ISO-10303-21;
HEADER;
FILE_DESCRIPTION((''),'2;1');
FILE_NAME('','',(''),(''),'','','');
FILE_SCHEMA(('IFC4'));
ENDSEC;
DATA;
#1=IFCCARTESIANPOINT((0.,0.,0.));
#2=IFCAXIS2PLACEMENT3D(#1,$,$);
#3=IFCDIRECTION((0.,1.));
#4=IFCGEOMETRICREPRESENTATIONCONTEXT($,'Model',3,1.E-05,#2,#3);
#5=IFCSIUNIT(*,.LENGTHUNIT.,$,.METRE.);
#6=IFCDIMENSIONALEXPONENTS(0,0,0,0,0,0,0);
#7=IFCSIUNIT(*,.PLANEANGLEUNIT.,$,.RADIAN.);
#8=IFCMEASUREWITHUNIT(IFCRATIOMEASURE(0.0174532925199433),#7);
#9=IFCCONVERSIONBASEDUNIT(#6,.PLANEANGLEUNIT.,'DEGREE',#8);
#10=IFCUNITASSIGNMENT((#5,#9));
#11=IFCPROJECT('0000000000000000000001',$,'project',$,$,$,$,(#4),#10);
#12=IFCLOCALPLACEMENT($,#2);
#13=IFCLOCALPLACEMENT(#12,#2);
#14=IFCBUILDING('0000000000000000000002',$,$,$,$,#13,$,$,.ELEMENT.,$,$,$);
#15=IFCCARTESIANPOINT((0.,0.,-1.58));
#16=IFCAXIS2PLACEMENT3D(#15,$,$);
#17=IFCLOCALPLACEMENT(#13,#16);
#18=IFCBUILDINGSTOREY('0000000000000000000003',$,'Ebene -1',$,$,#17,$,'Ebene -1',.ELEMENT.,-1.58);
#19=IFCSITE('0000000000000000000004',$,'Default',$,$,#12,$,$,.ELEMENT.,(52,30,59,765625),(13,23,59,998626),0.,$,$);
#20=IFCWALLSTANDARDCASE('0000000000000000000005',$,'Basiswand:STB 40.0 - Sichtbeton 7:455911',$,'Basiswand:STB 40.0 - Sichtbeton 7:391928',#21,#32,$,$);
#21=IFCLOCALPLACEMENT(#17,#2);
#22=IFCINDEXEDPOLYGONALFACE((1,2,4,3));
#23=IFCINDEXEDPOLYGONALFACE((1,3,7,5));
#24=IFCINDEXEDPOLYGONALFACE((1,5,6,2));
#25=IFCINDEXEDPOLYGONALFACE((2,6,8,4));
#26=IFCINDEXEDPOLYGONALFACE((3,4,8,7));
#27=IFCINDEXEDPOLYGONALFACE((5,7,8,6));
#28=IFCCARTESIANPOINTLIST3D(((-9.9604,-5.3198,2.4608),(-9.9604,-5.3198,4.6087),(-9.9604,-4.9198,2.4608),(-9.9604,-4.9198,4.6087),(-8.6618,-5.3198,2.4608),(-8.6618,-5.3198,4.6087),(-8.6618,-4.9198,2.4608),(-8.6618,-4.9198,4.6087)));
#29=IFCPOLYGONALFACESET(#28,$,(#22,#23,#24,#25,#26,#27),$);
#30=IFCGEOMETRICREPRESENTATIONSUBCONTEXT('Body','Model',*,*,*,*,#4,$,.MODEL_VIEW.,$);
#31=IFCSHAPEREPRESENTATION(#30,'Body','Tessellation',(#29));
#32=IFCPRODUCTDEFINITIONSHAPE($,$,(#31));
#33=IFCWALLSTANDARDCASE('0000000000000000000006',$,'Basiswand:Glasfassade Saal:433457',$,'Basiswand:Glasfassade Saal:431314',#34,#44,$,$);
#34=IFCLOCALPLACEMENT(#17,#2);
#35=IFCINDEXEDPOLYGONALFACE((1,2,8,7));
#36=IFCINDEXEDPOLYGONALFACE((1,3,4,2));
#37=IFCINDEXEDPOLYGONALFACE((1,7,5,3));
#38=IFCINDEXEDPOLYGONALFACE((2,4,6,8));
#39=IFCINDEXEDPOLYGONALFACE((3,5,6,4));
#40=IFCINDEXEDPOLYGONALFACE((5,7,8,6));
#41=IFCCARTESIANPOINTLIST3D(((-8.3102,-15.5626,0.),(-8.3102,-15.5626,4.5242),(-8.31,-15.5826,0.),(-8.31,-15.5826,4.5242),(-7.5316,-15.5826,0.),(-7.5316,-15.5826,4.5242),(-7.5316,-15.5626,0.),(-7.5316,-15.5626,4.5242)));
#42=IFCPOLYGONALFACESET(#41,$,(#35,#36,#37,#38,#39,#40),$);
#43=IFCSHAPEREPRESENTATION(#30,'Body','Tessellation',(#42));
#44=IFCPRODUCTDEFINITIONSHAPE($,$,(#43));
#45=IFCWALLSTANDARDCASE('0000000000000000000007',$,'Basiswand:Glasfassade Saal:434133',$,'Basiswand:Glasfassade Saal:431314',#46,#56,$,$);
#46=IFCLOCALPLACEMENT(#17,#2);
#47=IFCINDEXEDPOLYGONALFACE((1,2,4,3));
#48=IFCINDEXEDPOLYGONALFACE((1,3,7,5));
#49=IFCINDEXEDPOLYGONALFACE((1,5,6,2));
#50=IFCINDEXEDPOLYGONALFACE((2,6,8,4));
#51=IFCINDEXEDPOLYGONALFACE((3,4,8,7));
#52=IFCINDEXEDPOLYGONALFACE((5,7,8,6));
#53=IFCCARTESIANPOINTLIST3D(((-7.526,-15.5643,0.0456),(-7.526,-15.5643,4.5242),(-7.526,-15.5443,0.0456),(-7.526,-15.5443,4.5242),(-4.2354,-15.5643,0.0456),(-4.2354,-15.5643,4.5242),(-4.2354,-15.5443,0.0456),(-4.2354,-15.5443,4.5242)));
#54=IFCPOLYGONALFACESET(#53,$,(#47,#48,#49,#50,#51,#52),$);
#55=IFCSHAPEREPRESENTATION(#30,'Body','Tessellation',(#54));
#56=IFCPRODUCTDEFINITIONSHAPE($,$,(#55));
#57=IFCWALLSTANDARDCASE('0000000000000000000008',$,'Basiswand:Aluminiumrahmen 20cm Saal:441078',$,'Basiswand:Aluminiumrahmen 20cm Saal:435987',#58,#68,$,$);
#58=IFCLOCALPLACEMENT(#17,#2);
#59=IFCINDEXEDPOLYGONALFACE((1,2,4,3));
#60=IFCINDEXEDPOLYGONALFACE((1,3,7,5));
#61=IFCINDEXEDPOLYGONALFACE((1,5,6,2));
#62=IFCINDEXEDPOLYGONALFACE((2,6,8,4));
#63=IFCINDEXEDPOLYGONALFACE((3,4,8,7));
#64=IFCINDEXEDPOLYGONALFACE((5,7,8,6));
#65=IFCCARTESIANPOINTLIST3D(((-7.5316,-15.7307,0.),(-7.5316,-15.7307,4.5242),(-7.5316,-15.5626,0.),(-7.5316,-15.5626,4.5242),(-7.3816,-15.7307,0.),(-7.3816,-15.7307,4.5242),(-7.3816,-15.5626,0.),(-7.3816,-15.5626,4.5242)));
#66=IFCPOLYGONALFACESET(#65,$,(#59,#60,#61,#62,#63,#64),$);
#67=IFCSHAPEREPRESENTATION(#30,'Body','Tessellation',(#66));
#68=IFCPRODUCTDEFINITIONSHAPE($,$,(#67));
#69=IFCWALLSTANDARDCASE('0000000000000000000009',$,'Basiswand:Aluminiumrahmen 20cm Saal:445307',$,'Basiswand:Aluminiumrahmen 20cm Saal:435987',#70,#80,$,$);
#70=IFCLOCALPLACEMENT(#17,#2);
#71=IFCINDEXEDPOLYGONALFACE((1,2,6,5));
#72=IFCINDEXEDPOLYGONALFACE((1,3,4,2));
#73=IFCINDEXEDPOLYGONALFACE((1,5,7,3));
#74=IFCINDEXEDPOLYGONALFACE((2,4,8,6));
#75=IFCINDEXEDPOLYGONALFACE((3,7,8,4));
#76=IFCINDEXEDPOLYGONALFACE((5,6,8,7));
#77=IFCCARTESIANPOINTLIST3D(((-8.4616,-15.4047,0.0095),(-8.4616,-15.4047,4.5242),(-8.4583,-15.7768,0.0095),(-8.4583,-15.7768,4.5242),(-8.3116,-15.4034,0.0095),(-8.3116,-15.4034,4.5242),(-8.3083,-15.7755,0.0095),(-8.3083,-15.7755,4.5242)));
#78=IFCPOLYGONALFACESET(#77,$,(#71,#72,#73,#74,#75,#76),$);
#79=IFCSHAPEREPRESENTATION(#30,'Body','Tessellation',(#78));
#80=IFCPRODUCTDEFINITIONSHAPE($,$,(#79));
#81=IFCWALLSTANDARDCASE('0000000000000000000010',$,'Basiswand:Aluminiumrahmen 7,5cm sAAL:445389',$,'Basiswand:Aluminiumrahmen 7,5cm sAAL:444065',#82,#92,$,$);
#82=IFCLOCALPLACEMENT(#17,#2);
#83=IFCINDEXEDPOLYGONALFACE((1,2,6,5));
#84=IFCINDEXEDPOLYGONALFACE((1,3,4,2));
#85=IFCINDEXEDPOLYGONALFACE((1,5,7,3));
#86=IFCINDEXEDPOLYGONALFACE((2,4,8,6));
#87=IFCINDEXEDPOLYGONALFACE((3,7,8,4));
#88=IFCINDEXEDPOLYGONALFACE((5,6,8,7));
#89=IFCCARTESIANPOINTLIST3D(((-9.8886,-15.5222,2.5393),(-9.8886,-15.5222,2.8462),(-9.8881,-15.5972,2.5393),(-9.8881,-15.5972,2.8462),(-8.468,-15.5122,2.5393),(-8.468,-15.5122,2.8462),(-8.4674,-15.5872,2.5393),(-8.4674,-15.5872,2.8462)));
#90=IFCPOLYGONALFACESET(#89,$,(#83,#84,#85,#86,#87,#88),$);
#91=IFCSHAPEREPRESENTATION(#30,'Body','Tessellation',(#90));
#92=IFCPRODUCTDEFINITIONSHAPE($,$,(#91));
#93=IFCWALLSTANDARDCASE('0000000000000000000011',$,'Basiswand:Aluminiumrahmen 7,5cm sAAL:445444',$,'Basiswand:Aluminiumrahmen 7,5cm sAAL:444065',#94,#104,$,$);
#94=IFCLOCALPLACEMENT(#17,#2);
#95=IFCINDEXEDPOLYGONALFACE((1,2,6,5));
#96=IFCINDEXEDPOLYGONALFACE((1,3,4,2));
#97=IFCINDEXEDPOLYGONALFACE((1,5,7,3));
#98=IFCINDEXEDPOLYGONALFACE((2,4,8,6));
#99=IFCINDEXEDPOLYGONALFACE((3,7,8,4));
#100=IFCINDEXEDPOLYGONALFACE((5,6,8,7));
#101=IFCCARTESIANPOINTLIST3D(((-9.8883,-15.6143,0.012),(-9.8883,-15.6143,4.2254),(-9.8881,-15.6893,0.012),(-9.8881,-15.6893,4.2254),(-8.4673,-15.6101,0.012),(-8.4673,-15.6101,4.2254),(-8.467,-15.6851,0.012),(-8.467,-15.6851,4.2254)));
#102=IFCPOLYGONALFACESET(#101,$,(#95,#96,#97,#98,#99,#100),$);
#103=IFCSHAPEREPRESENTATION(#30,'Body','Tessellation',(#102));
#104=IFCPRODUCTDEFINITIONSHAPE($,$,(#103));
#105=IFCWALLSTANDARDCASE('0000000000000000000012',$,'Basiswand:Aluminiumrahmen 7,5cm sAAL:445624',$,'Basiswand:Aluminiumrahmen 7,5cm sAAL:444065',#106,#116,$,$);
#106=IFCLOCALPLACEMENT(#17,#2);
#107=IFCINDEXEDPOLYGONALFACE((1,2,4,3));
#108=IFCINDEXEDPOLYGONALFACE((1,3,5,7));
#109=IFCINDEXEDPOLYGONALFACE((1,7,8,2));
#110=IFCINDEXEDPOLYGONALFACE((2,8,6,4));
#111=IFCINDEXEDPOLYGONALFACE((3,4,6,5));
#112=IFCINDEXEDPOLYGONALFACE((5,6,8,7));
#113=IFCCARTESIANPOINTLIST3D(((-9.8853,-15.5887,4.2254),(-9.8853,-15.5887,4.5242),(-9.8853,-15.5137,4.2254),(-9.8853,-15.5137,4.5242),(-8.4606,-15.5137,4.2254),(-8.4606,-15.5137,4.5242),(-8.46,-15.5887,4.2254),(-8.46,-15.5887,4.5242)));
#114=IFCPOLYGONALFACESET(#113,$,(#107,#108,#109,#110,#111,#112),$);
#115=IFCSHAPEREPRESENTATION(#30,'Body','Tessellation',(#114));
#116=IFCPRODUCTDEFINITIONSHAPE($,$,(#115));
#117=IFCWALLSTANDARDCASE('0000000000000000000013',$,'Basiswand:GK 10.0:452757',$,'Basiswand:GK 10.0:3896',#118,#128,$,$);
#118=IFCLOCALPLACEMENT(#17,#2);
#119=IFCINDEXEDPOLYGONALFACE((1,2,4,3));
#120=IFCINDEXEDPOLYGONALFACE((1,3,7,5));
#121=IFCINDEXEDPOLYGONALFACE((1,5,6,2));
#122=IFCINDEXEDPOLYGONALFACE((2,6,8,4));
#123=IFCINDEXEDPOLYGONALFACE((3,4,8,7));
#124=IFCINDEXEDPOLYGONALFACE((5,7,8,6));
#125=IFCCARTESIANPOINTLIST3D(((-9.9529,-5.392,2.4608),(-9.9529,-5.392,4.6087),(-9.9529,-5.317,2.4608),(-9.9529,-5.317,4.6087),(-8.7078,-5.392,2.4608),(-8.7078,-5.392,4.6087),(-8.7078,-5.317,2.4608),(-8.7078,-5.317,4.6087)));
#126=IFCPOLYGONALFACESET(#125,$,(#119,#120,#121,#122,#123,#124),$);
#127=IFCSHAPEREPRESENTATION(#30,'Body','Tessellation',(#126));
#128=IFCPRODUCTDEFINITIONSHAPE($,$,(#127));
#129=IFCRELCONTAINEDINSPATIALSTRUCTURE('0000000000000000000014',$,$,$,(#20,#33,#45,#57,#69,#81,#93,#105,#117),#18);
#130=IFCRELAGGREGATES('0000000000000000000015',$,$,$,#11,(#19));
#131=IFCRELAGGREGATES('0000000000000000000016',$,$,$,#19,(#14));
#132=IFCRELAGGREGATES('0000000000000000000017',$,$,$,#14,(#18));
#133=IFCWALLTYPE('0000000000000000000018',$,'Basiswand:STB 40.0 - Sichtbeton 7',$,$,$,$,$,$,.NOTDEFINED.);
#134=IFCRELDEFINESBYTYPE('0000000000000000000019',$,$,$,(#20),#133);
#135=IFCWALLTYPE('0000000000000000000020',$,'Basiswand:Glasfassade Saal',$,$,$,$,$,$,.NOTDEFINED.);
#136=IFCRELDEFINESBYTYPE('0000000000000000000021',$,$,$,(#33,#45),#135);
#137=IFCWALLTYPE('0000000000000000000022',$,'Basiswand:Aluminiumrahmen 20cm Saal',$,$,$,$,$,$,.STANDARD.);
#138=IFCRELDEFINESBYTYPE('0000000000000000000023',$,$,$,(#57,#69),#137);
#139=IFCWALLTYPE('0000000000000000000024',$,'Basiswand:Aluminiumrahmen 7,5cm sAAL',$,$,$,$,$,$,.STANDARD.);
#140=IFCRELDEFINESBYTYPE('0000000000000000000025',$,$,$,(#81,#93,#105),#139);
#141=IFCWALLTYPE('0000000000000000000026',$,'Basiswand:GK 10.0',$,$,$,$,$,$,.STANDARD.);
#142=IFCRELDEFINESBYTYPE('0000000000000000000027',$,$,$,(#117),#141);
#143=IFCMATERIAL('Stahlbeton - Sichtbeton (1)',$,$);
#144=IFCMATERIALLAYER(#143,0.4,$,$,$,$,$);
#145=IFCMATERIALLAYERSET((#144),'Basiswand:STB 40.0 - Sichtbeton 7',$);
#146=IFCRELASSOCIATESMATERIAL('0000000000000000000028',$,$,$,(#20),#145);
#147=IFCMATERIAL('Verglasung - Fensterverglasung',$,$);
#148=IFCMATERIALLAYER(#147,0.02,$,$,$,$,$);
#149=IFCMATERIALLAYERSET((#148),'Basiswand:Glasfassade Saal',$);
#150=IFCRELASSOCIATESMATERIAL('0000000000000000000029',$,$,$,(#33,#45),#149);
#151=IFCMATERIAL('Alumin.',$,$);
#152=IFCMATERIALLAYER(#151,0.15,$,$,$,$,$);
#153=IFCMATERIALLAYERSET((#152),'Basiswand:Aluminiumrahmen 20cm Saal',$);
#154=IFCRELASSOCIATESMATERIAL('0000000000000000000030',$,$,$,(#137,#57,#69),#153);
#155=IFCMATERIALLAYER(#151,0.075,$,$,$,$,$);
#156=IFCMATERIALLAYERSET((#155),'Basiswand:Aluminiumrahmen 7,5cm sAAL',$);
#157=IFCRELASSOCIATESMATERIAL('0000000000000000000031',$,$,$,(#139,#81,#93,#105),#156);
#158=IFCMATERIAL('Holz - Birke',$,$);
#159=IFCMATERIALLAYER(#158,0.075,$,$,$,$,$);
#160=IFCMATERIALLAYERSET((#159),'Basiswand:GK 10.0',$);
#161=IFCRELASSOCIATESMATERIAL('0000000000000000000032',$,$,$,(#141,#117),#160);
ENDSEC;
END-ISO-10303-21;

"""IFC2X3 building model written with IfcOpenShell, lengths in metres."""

from ifc_helpers import new_model, entity, si_unit, converted_unit, direction, frame, frame_2d, origin, place, context, subcontext, project, spatial, polyline, rectangle, outline, extrude, clip, halfspace, material, layer, layer_set, layer_usage, type_object, element, save


model = new_model("IFC2X3")

# Units and contexts
model_context = context("Model", 3, precision=1e-05, world=origin(), true_north=direction((0.0, 1.0)))
body_context = subcontext(model_context, "Body", "Model", "MODEL_VIEW")
ifc_project = project(units=[si_unit("LENGTHUNIT", "METRE"), converted_unit("PLANEANGLEUNIT", "DEGREE", entity("IfcRatioMeasure", 0.0174532925199433), si_unit("PLANEANGLEUNIT", "RADIAN"), dimensions=[0, 0, 0, 0, 0, 0, 0])], contexts=[model_context])

# Site, building, storey
site_placement = place(None, origin())
site = spatial("IfcSite", under=ifc_project, at=site_placement, Name="Default", CompositionType="ELEMENT", RefLatitude=(52, 30, 59, 765625), RefLongitude=(13, 23, 59, 998626), RefElevation=0.0)
building_placement = place(site_placement, origin())
building = spatial("IfcBuilding", under=site, at=building_placement, CompositionType="ELEMENT")
storey_placement = place(building_placement, frame((0.0, 0.0, -1.58)))
storey = spatial("IfcBuildingStorey", under=building, at=storey_placement, Name="Ebene -1", LongName="Ebene -1", CompositionType="ELEMENT", Elevation=-1.58)

# Walls
ifc_material_1 = material(Name="Stahlbeton - Sichtbeton (1)")
ifc_material_2 = material(Name="Alumin.")
ifc_layer_1 = layer(ifc_material_1, 0.4)
ifc_layer_set_1 = layer_set([ifc_layer_1], Name="Basiswand:STB 40.0 - Sichtbeton 7")
wall_type_1 = type_object("IfcWallType", Name="Basiswand:STB 40.0 - Sichtbeton 7", PredefinedType="NOTDEFINED")
ifc_layer_usage_1 = layer_usage(ifc_layer_set_1, "AXIS2", "POSITIVE", -0.2)
wall_1_placement = place(storey_placement, frame((-8.6618, -5.1198, 2.4608), z_axis=(0.0, 0.0, 1.0), x_axis=(-1.0, 0.0, 0.0)))
element("IfcWallStandardCase", 1, at=wall_1_placement, inside=storey, type_object=wall_type_1, material=ifc_layer_usage_1, Name="Basiswand:STB 40.0 - Sichtbeton 7:455911", ObjectType="Basiswand:STB 40.0 - Sichtbeton 7:391928", context=body_context, shape_type="Clipping", body=[
    clip(extrude(rectangle(XDim=1.2986, YDim=0.4, at=frame_2d((0.6493, 0.0), x_axis=(-1.0, 0.0))), origin(), (0.0, 0.0, 1.0), 2.1479), halfspace(frame((1.2986, -0.2, 0.0), z_axis=(0.0, 0.0, -1.0), x_axis=(0.0, 1.0, 0.0)), False)),
])
ifc_material_3 = material(Name="Verglasung - Fensterverglasung")
ifc_layer_2 = layer(ifc_material_3, 0.02)
ifc_layer_set_2 = layer_set([ifc_layer_2], Name="Basiswand:Glasfassade Saal")
ifc_layer_usage_2 = layer_usage(ifc_layer_set_2, "AXIS2", "NEGATIVE", 0.01)
wall_type_2 = type_object("IfcWallType", Name="Basiswand:Glasfassade Saal", PredefinedType="NOTDEFINED")
wall_2_placement = place(storey_placement, frame((-7.5316, -15.5726, 0.0), z_axis=(0.0, 0.0, 1.0), x_axis=(-1.0, 0.0, 0.0)))
element("IfcWallStandardCase", 2, at=wall_2_placement, inside=storey, type_object=wall_type_2, material=ifc_layer_usage_2, Name="Basiswand:Glasfassade Saal:433457", ObjectType="Basiswand:Glasfassade Saal:431314", context=body_context, shape_type="SweptSolid", body=[
    extrude(outline(polyline([(0.7786, -0.01), (0.7784, 0.01), (0.0, 0.01), (0.0, -0.01), (0.7786, -0.01)])), origin(), (0.0, 0.0, 1.0), 4.5242),
])
ifc_layer_usage_3 = layer_usage(ifc_layer_set_2, "AXIS2", "NEGATIVE", 0.01)
wall_3_placement = place(storey_placement, frame((-7.526, -15.5543, 0.0456)))
element("IfcWallStandardCase", 3, at=wall_3_placement, inside=storey, type_object=wall_type_2, material=ifc_layer_usage_3, Name="Basiswand:Glasfassade Saal:434133", ObjectType="Basiswand:Glasfassade Saal:431314", context=body_context, shape_type="SweptSolid", body=[
    extrude(rectangle(XDim=3.2906, YDim=0.02, at=frame_2d((1.6453, 0.0), x_axis=(-1.0, 0.0))), origin(), (0.0, 0.0, 1.0), 4.4786),
])
ifc_layer_3 = layer(ifc_material_2, 0.15)
ifc_layer_set_3 = layer_set([ifc_layer_3], Name="Basiswand:Aluminiumrahmen 20cm Saal")
ifc_layer_usage_4 = layer_usage(ifc_layer_set_3, "AXIS2", "POSITIVE", -0.075)
wall_type_3 = type_object("IfcWallType", Name="Basiswand:Aluminiumrahmen 20cm Saal", PredefinedType="STANDARD", material=ifc_layer_set_3)
wall_4_placement = place(storey_placement, frame((-7.4566, -15.7307, 0.0), z_axis=(0.0, 0.0, 1.0), x_axis=(0.0, 1.0, 0.0)))
element("IfcWallStandardCase", 4, at=wall_4_placement, inside=storey, type_object=wall_type_3, material=ifc_layer_usage_4, Name="Basiswand:Aluminiumrahmen 20cm Saal:441078", ObjectType="Basiswand:Aluminiumrahmen 20cm Saal:435987", context=body_context, shape_type="SweptSolid", body=[
    extrude(rectangle(XDim=0.1681, YDim=0.15, at=frame_2d((0.084, 0.0), x_axis=(-1.0, 0.0))), origin(), (0.0, 0.0, 1.0), 4.5242),
])
ifc_layer_usage_5 = layer_usage(ifc_layer_set_3, "AXIS2", "POSITIVE", -0.075)
wall_5_placement = place(storey_placement, frame((-8.3866, -15.404, 0.0095), z_axis=(0.0, 0.0, 1.0), x_axis=(0.008751, -0.999962, 0.0)))
element("IfcWallStandardCase", 5, at=wall_5_placement, inside=storey, type_object=wall_type_3, material=ifc_layer_usage_5, Name="Basiswand:Aluminiumrahmen 20cm Saal:445307", ObjectType="Basiswand:Aluminiumrahmen 20cm Saal:435987", context=body_context, shape_type="SweptSolid", body=[
    extrude(rectangle(XDim=0.3721, YDim=0.15, at=frame_2d((0.1861, 0.0), x_axis=(-1.0, 0.0))), origin(), (0.0, 0.0, 1.0), 4.5147),
])
ifc_layer_4 = layer(ifc_material_2, 0.075)
ifc_layer_set_4 = layer_set([ifc_layer_4], Name="Basiswand:Aluminiumrahmen 7,5cm sAAL")
ifc_layer_usage_6 = layer_usage(ifc_layer_set_4, "AXIS2", "POSITIVE", -0.0375)
wall_type_4 = type_object("IfcWallType", Name="Basiswand:Aluminiumrahmen 7,5cm sAAL", PredefinedType="STANDARD", material=ifc_layer_set_4)
wall_6_placement = place(storey_placement, frame((-9.8884, -15.5597, 2.5393), z_axis=(0.0, 0.0, 1.0), x_axis=(0.999975, 0.007018, 0.0)))
element("IfcWallStandardCase", 6, at=wall_6_placement, inside=storey, type_object=wall_type_4, material=ifc_layer_usage_6, Name="Basiswand:Aluminiumrahmen 7,5cm sAAL:445389", ObjectType="Basiswand:Aluminiumrahmen 7,5cm sAAL:444065", context=body_context, shape_type="SweptSolid", body=[
    extrude(rectangle(XDim=1.4207, YDim=0.075, at=frame_2d((0.7103, 0.0), x_axis=(-1.0, 0.0))), origin(), (0.0, 0.0, 1.0), 0.3069),
])
ifc_layer_usage_7 = layer_usage(ifc_layer_set_4, "AXIS2", "POSITIVE", -0.0375)
wall_7_placement = place(storey_placement, frame((-8.4671, -15.6476, 0.012), z_axis=(0.0, 0.0, 1.0), x_axis=(-0.999995, -0.003002, 0.0)))
element("IfcWallStandardCase", 7, at=wall_7_placement, inside=storey, type_object=wall_type_4, material=ifc_layer_usage_7, Name="Basiswand:Aluminiumrahmen 7,5cm sAAL:445444", ObjectType="Basiswand:Aluminiumrahmen 7,5cm sAAL:444065", context=body_context, shape_type="SweptSolid", body=[
    extrude(rectangle(XDim=1.421, YDim=0.075, at=frame_2d((0.7105, 0.0), x_axis=(-1.0, 0.0))), origin(), (0.0, 0.0, 1.0), 4.2134),
])
ifc_layer_usage_8 = layer_usage(ifc_layer_set_4, "AXIS2", "POSITIVE", -0.0375)
wall_8_placement = place(storey_placement, frame((-9.8853, -15.5512, 4.2254)))
element("IfcWallStandardCase", 8, at=wall_8_placement, inside=storey, type_object=wall_type_4, material=ifc_layer_usage_8, Name="Basiswand:Aluminiumrahmen 7,5cm sAAL:445624", ObjectType="Basiswand:Aluminiumrahmen 7,5cm sAAL:444065", context=body_context, shape_type="SweptSolid", body=[
    extrude(outline(polyline([(1.4253, -0.0375), (1.4247, 0.0375), (0.0, 0.0375), (0.0, -0.0375), (1.4253, -0.0375)])), origin(), (0.0, 0.0, 1.0), 0.2988),
])
ifc_material_4 = material(Name="Holz - Birke")
ifc_layer_5 = layer(ifc_material_4, 0.075)
ifc_layer_set_5 = layer_set([ifc_layer_5], Name="Basiswand:GK 10.0")
ifc_layer_usage_9 = layer_usage(ifc_layer_set_5, "AXIS2", "POSITIVE", -0.0375)
wall_type_5 = type_object("IfcWallType", Name="Basiswand:GK 10.0", PredefinedType="STANDARD", material=ifc_layer_set_5)
wall_9_placement = place(storey_placement, frame((-9.9529, -5.3545, 2.4608)))
element("IfcWallStandardCase", 9, at=wall_9_placement, inside=storey, type_object=wall_type_5, material=ifc_layer_usage_9, Name="Basiswand:GK 10.0:452757", ObjectType="Basiswand:GK 10.0:3896", context=body_context, shape_type="SweptSolid", body=[
    extrude(rectangle(XDim=1.245, YDim=0.075, at=frame_2d((0.6225, 0.0), x_axis=(-1.0, 0.0))), origin(), (0.0, 0.0, 1.0), 2.1479),
])

save(model, "model.ifc")
